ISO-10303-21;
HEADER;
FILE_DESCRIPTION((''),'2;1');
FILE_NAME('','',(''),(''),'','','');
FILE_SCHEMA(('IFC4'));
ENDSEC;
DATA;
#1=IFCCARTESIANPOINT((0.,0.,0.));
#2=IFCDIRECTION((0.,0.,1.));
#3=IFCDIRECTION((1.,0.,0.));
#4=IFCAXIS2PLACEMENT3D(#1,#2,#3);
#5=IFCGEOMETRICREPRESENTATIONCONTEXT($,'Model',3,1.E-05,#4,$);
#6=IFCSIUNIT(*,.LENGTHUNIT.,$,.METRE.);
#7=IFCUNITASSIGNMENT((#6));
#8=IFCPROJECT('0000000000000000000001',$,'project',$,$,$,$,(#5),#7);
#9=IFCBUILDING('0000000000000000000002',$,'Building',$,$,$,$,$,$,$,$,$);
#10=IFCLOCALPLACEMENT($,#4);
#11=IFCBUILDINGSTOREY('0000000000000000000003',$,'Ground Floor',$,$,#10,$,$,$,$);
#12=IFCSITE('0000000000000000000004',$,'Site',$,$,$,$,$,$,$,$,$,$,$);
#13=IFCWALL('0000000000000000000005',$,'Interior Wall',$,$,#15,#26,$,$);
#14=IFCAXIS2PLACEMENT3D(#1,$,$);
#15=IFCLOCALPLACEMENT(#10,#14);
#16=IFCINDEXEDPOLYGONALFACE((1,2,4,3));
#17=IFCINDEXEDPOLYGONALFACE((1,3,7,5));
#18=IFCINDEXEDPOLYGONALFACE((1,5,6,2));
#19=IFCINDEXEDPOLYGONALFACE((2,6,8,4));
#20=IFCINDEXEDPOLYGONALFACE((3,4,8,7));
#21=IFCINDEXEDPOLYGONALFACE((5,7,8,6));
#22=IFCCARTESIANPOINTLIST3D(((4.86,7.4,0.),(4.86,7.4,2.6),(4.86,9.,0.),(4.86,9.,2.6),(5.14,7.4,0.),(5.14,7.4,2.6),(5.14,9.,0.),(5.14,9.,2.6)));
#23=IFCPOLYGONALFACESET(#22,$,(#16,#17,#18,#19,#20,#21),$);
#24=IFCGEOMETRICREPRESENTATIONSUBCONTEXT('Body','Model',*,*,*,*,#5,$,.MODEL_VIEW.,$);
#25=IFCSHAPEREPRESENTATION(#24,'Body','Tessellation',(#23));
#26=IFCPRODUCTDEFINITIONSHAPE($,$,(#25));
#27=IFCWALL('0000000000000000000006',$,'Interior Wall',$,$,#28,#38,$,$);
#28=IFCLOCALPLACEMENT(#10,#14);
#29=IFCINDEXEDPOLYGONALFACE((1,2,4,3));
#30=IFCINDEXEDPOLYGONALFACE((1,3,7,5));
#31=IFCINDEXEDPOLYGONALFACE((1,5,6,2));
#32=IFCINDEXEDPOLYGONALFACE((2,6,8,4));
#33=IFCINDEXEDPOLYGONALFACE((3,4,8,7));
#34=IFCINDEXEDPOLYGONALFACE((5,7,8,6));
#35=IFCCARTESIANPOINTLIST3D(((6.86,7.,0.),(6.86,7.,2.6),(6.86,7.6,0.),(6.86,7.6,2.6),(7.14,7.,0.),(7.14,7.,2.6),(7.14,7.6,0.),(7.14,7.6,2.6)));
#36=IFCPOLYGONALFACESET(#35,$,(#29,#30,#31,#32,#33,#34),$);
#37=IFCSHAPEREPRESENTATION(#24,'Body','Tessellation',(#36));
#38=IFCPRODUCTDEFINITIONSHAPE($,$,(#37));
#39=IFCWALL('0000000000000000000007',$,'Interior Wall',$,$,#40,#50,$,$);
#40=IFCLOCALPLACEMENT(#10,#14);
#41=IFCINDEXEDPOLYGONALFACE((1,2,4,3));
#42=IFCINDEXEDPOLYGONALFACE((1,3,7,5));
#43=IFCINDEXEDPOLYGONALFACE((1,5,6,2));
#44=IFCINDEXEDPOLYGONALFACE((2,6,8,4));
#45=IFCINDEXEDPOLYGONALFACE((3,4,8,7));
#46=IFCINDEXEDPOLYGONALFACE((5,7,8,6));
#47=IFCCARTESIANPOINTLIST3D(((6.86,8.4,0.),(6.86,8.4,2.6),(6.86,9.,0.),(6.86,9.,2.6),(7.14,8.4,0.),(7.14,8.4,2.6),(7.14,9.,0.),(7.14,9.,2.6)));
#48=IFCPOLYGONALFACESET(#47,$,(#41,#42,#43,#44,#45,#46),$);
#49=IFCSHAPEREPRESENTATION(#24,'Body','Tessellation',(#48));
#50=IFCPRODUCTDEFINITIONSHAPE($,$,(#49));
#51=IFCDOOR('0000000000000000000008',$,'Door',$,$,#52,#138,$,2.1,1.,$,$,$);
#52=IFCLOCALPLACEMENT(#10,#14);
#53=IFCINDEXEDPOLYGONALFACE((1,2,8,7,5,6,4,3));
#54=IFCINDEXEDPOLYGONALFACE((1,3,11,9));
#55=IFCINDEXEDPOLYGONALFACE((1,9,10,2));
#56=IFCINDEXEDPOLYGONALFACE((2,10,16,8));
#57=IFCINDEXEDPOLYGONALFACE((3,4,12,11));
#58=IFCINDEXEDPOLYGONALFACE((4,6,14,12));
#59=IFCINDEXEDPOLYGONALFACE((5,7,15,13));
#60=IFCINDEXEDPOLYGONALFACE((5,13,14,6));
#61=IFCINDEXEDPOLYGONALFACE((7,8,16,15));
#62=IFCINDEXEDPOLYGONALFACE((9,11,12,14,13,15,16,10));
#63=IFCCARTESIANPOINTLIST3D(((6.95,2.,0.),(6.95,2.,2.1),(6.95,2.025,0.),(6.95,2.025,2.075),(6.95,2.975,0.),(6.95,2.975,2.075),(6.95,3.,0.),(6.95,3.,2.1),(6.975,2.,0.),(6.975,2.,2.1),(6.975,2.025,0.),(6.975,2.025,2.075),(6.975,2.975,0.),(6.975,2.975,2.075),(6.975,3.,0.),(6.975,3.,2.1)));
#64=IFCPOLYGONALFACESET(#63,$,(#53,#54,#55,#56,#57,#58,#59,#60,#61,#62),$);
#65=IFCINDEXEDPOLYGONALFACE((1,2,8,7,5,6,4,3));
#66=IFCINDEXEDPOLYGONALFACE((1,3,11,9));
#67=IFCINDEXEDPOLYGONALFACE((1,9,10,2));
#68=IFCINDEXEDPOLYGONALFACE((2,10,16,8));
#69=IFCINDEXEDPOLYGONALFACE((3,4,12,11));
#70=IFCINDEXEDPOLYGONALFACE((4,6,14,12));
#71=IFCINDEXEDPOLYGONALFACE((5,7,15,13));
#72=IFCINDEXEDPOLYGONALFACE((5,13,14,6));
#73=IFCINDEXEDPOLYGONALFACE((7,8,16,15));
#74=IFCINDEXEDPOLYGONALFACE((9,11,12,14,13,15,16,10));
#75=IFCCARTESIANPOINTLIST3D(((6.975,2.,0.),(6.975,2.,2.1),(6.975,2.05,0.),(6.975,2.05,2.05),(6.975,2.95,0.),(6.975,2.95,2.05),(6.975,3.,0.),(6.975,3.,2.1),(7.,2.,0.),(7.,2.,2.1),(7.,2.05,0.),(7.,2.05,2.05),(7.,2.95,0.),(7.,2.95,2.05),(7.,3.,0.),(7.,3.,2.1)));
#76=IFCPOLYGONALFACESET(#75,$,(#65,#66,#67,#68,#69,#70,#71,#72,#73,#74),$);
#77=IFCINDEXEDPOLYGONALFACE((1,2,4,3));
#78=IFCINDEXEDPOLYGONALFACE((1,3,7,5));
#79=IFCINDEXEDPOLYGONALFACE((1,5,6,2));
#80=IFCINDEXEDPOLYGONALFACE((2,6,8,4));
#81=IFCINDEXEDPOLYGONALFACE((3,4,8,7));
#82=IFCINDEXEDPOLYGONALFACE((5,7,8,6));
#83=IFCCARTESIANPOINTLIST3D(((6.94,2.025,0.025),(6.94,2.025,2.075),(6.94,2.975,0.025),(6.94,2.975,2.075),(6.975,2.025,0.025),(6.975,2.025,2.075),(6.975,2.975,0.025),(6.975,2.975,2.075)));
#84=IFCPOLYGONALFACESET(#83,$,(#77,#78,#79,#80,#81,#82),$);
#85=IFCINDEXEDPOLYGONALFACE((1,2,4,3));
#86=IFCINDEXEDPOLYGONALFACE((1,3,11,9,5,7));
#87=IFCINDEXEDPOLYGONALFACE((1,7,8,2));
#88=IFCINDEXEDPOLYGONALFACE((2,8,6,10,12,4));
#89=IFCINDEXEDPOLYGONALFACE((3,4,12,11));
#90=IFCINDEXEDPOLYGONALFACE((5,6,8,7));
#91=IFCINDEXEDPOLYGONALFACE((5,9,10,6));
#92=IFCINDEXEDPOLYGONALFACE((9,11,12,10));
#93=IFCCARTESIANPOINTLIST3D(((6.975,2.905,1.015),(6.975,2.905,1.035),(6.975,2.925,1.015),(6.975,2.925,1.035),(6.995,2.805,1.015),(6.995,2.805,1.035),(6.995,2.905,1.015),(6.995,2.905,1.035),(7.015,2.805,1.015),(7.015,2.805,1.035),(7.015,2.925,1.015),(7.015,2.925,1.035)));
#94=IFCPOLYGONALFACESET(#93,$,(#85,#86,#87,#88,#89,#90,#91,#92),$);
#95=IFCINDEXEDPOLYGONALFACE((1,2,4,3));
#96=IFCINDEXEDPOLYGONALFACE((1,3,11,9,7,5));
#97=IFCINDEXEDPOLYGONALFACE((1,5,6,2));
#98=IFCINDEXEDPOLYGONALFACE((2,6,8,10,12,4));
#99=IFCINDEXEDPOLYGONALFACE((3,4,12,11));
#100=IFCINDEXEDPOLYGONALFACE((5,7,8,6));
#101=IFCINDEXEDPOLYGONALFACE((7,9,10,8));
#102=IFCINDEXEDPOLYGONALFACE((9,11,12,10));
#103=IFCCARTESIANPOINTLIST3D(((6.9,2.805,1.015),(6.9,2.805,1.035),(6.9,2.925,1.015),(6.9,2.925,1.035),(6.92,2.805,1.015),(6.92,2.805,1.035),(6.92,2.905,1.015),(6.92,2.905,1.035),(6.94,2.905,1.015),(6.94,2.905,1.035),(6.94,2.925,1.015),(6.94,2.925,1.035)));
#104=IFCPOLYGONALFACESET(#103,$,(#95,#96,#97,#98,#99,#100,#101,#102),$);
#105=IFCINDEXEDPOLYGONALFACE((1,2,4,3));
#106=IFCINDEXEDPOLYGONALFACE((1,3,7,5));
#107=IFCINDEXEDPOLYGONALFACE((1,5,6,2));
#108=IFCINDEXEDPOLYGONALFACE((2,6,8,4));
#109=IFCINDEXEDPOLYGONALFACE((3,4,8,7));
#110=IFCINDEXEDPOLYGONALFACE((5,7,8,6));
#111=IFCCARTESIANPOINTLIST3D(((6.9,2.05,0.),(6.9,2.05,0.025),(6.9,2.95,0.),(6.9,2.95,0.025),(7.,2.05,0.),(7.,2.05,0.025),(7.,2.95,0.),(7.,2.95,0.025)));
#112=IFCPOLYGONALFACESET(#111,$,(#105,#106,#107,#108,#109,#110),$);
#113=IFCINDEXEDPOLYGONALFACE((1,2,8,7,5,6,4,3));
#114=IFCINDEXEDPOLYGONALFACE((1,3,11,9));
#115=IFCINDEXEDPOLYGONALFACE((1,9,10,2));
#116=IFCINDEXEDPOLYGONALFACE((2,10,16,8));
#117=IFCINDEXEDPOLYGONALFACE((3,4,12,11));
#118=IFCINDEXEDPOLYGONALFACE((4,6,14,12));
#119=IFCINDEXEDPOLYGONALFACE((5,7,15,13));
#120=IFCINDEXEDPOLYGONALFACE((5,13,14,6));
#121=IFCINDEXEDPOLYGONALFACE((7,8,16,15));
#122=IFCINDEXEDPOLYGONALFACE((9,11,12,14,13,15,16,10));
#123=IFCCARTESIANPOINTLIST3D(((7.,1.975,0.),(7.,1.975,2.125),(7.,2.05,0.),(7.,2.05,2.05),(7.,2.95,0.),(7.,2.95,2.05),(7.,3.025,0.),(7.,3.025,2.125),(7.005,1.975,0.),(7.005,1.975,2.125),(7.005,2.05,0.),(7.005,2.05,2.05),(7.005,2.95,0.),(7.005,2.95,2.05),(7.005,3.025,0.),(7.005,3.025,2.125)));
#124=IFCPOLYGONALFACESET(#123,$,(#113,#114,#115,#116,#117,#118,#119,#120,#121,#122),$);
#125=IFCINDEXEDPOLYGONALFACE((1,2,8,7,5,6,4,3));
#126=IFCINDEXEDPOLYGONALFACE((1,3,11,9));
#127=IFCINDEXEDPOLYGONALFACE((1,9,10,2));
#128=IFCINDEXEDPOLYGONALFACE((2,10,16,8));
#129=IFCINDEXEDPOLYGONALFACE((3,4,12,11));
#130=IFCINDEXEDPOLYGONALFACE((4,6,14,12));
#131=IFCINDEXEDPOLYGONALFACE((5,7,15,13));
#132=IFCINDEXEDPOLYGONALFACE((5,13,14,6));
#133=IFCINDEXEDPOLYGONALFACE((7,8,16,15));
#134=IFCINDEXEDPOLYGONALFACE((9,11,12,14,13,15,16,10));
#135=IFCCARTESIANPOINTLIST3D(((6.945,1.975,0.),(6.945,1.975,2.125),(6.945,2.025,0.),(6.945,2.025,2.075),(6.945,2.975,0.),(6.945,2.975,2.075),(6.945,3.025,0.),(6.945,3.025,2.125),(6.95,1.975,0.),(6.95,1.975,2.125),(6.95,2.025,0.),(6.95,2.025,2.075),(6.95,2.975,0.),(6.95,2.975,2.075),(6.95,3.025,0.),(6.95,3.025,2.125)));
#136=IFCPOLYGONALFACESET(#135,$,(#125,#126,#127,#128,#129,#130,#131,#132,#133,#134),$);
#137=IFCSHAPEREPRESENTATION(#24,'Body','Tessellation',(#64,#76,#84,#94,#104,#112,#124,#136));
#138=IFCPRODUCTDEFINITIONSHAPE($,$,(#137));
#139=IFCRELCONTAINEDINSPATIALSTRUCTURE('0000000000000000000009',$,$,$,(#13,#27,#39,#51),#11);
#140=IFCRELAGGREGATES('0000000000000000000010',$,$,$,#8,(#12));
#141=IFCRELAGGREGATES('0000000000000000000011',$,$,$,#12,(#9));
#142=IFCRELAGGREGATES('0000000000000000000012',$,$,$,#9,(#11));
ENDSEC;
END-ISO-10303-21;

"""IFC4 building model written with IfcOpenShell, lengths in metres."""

from ifc_helpers import new_model, si_unit, frame, origin_with_axes, place, context, subcontext, project, spatial, line, indexed_curve, outline, extrude, element, save


model = new_model("IFC4")

# Units and contexts
model_context = context("Model", 3, precision=1e-05, world=origin_with_axes())
body_context = subcontext(model_context, "Body", "Model", "MODEL_VIEW")
ifc_project = project(units=[si_unit("LENGTHUNIT", "METRE")], contexts=[model_context])

# Site, building, storey
site = spatial("IfcSite", under=ifc_project, Name="Site")
building = spatial("IfcBuilding", under=site, Name="Building")
storey_placement = place(None, origin_with_axes())
storey = spatial("IfcBuildingStorey", under=building, at=storey_placement, Name="Ground Floor")

# Walls
for number, where, z_axis, x_axis, name in (
    (1, (5.0, 7.4, 0.0), (0.0, 0.0, 1.0), (0.0, 1.0, 0.0), "Interior Wall"),
):
    element("IfcWall", number, at=place(storey_placement, frame(where, z_axis=z_axis, x_axis=x_axis)), inside=storey, Name=name, context=body_context, shape_type="SweptSolid", body=[
        extrude(outline(indexed_curve([(0.0, 0.0), (0.0, 0.28), (1.6, 0.28), (1.6, 0.0), (0.0, 0.0)], self_intersect=False)), frame((0.0, -0.14, 0.0), z_axis=(0.0, 0.0, 1.0), x_axis=(1.0, 0.0, 0.0)), (0.0, 0.0, 1.0), 2.6),
    ])
for number, where, z_axis, x_axis, name in (
    (2, (7.0, 7.0, 0.0), (0.0, 0.0, 1.0), (0.0, 1.0, 0.0), "Interior Wall"),
    (3, (7.0, 8.4, 0.0), (0.0, 0.0, 1.0), (0.0, 1.0, 0.0), "Interior Wall"),
):
    element("IfcWall", number, at=place(storey_placement, frame(where, z_axis=z_axis, x_axis=x_axis)), inside=storey, Name=name, context=body_context, shape_type="SweptSolid", body=[
        extrude(outline(indexed_curve([(0.0, 0.0), (0.0, 0.28), (0.6, 0.28), (0.6, 0.0), (0.0, 0.0)], self_intersect=False)), frame((0.0, -0.14, 0.0), z_axis=(0.0, 0.0, 1.0), x_axis=(1.0, 0.0, 0.0)), (0.0, 0.0, 1.0), 2.6),
    ])

# Door
door_1_placement = place(storey_placement, frame((7.0, 2.0, 0.0), z_axis=(0.0, 0.0, 1.0), x_axis=(0.0, 1.0, 0.0)))
element("IfcDoor", 4, at=door_1_placement, inside=storey, Name="Door", OverallHeight=2.1, OverallWidth=1.0, context=body_context, shape_type="SweptSolid", body=[
    extrude(outline(indexed_curve([(0.0, 0.0), (0.0, 2.1), (1.0, 2.1), (1.0, 0.0), (0.975, 0.0), (0.975, 2.075), (0.025, 2.075), (0.025, 0.0)], segments=[line(1, 2, 3, 4, 5, 6, 7, 8, 1)])), frame((0.0, 0.025, 0.0), z_axis=(0.0, -1.0, 0.0), x_axis=(1.0, 0.0, 0.0)), (0.0, 0.0, -1.0), 0.025),
    extrude(outline(indexed_curve([(0.0, 0.0), (0.0, 2.1), (1.0, 2.1), (1.0, 0.0), (0.95, 0.0), (0.95, 2.05), (0.05, 2.05), (0.05, 0.0)], segments=[line(1, 2, 3, 4, 5, 6, 7, 8, 1)])), frame((0.0, 0.0, 0.0), z_axis=(0.0, -1.0, 0.0), x_axis=(1.0, 0.0, 0.0)), (0.0, 0.0, -1.0), 0.025),
    extrude(outline(indexed_curve([(0.0, 0.0), (0.95, 0.0), (0.95, 0.035), (0.0, 0.035)], segments=[line(1, 2, 3, 4, 1)])), frame((0.025, 0.025, 0.025), z_axis=(0.0, 0.0, 1.0), x_axis=(1.0, 0.0, 0.0)), (0.0, 0.0, 1.0), 2.05),
    extrude(outline(indexed_curve([(0.0, 0.0), (0.0, -0.04), (-0.12, -0.04), (-0.12, -0.02), (-0.02, -0.02), (-0.02, 0.0)], segments=[line(1, 2, 3, 4, 5, 6, 1)])), frame((0.925, 0.025, 1.015), z_axis=(0.0, 0.0, 1.0), x_axis=(1.0, 0.0, 0.0)), (0.0, 0.0, 1.0), 0.02),
    extrude(outline(indexed_curve([(0.0, 0.0), (0.0, 0.04), (-0.12, 0.04), (-0.12, 0.02), (-0.02, 0.02), (-0.02, 0.0)], segments=[line(1, 2, 3, 4, 5, 6, 1)])), frame((0.925, 0.06, 1.015), z_axis=(0.0, 0.0, 1.0), x_axis=(1.0, 0.0, 0.0)), (0.0, 0.0, 1.0), 0.02),
    extrude(outline(indexed_curve([(0.0, 0.0), (0.9, 0.0), (0.9, 0.1), (0.0, 0.1)], segments=[line(1, 2, 3, 4, 1)])), frame((0.05, 0.0, 0.0), z_axis=(0.0, 0.0, 1.0), x_axis=(1.0, 0.0, 0.0)), (0.0, 0.0, 1.0), 0.025),
    extrude(outline(indexed_curve([(0.0, 0.0), (0.0, 2.125), (1.05, 2.125), (1.05, 0.0), (0.975, 0.0), (0.975, 2.05), (0.075, 2.05), (0.075, 0.0)], segments=[line(1, 2, 3, 4, 5, 6, 7, 8, 1)])), frame((-0.025, -0.005, 0.0), z_axis=(0.0, -1.0, 0.0), x_axis=(1.0, 0.0, 0.0)), (0.0, 0.0, -1.0), 0.005),
    extrude(outline(indexed_curve([(0.0, 0.0), (0.0, 2.125), (1.05, 2.125), (1.05, 0.0), (1.0, 0.0), (1.0, 2.075), (0.05, 2.075), (0.05, 0.0)], segments=[line(1, 2, 3, 4, 5, 6, 7, 8, 1)])), frame((-0.025, 0.05, 0.0), z_axis=(0.0, -1.0, 0.0), x_axis=(1.0, 0.0, 0.0)), (0.0, 0.0, -1.0), 0.005),
])

save(model, "model.ifc")
